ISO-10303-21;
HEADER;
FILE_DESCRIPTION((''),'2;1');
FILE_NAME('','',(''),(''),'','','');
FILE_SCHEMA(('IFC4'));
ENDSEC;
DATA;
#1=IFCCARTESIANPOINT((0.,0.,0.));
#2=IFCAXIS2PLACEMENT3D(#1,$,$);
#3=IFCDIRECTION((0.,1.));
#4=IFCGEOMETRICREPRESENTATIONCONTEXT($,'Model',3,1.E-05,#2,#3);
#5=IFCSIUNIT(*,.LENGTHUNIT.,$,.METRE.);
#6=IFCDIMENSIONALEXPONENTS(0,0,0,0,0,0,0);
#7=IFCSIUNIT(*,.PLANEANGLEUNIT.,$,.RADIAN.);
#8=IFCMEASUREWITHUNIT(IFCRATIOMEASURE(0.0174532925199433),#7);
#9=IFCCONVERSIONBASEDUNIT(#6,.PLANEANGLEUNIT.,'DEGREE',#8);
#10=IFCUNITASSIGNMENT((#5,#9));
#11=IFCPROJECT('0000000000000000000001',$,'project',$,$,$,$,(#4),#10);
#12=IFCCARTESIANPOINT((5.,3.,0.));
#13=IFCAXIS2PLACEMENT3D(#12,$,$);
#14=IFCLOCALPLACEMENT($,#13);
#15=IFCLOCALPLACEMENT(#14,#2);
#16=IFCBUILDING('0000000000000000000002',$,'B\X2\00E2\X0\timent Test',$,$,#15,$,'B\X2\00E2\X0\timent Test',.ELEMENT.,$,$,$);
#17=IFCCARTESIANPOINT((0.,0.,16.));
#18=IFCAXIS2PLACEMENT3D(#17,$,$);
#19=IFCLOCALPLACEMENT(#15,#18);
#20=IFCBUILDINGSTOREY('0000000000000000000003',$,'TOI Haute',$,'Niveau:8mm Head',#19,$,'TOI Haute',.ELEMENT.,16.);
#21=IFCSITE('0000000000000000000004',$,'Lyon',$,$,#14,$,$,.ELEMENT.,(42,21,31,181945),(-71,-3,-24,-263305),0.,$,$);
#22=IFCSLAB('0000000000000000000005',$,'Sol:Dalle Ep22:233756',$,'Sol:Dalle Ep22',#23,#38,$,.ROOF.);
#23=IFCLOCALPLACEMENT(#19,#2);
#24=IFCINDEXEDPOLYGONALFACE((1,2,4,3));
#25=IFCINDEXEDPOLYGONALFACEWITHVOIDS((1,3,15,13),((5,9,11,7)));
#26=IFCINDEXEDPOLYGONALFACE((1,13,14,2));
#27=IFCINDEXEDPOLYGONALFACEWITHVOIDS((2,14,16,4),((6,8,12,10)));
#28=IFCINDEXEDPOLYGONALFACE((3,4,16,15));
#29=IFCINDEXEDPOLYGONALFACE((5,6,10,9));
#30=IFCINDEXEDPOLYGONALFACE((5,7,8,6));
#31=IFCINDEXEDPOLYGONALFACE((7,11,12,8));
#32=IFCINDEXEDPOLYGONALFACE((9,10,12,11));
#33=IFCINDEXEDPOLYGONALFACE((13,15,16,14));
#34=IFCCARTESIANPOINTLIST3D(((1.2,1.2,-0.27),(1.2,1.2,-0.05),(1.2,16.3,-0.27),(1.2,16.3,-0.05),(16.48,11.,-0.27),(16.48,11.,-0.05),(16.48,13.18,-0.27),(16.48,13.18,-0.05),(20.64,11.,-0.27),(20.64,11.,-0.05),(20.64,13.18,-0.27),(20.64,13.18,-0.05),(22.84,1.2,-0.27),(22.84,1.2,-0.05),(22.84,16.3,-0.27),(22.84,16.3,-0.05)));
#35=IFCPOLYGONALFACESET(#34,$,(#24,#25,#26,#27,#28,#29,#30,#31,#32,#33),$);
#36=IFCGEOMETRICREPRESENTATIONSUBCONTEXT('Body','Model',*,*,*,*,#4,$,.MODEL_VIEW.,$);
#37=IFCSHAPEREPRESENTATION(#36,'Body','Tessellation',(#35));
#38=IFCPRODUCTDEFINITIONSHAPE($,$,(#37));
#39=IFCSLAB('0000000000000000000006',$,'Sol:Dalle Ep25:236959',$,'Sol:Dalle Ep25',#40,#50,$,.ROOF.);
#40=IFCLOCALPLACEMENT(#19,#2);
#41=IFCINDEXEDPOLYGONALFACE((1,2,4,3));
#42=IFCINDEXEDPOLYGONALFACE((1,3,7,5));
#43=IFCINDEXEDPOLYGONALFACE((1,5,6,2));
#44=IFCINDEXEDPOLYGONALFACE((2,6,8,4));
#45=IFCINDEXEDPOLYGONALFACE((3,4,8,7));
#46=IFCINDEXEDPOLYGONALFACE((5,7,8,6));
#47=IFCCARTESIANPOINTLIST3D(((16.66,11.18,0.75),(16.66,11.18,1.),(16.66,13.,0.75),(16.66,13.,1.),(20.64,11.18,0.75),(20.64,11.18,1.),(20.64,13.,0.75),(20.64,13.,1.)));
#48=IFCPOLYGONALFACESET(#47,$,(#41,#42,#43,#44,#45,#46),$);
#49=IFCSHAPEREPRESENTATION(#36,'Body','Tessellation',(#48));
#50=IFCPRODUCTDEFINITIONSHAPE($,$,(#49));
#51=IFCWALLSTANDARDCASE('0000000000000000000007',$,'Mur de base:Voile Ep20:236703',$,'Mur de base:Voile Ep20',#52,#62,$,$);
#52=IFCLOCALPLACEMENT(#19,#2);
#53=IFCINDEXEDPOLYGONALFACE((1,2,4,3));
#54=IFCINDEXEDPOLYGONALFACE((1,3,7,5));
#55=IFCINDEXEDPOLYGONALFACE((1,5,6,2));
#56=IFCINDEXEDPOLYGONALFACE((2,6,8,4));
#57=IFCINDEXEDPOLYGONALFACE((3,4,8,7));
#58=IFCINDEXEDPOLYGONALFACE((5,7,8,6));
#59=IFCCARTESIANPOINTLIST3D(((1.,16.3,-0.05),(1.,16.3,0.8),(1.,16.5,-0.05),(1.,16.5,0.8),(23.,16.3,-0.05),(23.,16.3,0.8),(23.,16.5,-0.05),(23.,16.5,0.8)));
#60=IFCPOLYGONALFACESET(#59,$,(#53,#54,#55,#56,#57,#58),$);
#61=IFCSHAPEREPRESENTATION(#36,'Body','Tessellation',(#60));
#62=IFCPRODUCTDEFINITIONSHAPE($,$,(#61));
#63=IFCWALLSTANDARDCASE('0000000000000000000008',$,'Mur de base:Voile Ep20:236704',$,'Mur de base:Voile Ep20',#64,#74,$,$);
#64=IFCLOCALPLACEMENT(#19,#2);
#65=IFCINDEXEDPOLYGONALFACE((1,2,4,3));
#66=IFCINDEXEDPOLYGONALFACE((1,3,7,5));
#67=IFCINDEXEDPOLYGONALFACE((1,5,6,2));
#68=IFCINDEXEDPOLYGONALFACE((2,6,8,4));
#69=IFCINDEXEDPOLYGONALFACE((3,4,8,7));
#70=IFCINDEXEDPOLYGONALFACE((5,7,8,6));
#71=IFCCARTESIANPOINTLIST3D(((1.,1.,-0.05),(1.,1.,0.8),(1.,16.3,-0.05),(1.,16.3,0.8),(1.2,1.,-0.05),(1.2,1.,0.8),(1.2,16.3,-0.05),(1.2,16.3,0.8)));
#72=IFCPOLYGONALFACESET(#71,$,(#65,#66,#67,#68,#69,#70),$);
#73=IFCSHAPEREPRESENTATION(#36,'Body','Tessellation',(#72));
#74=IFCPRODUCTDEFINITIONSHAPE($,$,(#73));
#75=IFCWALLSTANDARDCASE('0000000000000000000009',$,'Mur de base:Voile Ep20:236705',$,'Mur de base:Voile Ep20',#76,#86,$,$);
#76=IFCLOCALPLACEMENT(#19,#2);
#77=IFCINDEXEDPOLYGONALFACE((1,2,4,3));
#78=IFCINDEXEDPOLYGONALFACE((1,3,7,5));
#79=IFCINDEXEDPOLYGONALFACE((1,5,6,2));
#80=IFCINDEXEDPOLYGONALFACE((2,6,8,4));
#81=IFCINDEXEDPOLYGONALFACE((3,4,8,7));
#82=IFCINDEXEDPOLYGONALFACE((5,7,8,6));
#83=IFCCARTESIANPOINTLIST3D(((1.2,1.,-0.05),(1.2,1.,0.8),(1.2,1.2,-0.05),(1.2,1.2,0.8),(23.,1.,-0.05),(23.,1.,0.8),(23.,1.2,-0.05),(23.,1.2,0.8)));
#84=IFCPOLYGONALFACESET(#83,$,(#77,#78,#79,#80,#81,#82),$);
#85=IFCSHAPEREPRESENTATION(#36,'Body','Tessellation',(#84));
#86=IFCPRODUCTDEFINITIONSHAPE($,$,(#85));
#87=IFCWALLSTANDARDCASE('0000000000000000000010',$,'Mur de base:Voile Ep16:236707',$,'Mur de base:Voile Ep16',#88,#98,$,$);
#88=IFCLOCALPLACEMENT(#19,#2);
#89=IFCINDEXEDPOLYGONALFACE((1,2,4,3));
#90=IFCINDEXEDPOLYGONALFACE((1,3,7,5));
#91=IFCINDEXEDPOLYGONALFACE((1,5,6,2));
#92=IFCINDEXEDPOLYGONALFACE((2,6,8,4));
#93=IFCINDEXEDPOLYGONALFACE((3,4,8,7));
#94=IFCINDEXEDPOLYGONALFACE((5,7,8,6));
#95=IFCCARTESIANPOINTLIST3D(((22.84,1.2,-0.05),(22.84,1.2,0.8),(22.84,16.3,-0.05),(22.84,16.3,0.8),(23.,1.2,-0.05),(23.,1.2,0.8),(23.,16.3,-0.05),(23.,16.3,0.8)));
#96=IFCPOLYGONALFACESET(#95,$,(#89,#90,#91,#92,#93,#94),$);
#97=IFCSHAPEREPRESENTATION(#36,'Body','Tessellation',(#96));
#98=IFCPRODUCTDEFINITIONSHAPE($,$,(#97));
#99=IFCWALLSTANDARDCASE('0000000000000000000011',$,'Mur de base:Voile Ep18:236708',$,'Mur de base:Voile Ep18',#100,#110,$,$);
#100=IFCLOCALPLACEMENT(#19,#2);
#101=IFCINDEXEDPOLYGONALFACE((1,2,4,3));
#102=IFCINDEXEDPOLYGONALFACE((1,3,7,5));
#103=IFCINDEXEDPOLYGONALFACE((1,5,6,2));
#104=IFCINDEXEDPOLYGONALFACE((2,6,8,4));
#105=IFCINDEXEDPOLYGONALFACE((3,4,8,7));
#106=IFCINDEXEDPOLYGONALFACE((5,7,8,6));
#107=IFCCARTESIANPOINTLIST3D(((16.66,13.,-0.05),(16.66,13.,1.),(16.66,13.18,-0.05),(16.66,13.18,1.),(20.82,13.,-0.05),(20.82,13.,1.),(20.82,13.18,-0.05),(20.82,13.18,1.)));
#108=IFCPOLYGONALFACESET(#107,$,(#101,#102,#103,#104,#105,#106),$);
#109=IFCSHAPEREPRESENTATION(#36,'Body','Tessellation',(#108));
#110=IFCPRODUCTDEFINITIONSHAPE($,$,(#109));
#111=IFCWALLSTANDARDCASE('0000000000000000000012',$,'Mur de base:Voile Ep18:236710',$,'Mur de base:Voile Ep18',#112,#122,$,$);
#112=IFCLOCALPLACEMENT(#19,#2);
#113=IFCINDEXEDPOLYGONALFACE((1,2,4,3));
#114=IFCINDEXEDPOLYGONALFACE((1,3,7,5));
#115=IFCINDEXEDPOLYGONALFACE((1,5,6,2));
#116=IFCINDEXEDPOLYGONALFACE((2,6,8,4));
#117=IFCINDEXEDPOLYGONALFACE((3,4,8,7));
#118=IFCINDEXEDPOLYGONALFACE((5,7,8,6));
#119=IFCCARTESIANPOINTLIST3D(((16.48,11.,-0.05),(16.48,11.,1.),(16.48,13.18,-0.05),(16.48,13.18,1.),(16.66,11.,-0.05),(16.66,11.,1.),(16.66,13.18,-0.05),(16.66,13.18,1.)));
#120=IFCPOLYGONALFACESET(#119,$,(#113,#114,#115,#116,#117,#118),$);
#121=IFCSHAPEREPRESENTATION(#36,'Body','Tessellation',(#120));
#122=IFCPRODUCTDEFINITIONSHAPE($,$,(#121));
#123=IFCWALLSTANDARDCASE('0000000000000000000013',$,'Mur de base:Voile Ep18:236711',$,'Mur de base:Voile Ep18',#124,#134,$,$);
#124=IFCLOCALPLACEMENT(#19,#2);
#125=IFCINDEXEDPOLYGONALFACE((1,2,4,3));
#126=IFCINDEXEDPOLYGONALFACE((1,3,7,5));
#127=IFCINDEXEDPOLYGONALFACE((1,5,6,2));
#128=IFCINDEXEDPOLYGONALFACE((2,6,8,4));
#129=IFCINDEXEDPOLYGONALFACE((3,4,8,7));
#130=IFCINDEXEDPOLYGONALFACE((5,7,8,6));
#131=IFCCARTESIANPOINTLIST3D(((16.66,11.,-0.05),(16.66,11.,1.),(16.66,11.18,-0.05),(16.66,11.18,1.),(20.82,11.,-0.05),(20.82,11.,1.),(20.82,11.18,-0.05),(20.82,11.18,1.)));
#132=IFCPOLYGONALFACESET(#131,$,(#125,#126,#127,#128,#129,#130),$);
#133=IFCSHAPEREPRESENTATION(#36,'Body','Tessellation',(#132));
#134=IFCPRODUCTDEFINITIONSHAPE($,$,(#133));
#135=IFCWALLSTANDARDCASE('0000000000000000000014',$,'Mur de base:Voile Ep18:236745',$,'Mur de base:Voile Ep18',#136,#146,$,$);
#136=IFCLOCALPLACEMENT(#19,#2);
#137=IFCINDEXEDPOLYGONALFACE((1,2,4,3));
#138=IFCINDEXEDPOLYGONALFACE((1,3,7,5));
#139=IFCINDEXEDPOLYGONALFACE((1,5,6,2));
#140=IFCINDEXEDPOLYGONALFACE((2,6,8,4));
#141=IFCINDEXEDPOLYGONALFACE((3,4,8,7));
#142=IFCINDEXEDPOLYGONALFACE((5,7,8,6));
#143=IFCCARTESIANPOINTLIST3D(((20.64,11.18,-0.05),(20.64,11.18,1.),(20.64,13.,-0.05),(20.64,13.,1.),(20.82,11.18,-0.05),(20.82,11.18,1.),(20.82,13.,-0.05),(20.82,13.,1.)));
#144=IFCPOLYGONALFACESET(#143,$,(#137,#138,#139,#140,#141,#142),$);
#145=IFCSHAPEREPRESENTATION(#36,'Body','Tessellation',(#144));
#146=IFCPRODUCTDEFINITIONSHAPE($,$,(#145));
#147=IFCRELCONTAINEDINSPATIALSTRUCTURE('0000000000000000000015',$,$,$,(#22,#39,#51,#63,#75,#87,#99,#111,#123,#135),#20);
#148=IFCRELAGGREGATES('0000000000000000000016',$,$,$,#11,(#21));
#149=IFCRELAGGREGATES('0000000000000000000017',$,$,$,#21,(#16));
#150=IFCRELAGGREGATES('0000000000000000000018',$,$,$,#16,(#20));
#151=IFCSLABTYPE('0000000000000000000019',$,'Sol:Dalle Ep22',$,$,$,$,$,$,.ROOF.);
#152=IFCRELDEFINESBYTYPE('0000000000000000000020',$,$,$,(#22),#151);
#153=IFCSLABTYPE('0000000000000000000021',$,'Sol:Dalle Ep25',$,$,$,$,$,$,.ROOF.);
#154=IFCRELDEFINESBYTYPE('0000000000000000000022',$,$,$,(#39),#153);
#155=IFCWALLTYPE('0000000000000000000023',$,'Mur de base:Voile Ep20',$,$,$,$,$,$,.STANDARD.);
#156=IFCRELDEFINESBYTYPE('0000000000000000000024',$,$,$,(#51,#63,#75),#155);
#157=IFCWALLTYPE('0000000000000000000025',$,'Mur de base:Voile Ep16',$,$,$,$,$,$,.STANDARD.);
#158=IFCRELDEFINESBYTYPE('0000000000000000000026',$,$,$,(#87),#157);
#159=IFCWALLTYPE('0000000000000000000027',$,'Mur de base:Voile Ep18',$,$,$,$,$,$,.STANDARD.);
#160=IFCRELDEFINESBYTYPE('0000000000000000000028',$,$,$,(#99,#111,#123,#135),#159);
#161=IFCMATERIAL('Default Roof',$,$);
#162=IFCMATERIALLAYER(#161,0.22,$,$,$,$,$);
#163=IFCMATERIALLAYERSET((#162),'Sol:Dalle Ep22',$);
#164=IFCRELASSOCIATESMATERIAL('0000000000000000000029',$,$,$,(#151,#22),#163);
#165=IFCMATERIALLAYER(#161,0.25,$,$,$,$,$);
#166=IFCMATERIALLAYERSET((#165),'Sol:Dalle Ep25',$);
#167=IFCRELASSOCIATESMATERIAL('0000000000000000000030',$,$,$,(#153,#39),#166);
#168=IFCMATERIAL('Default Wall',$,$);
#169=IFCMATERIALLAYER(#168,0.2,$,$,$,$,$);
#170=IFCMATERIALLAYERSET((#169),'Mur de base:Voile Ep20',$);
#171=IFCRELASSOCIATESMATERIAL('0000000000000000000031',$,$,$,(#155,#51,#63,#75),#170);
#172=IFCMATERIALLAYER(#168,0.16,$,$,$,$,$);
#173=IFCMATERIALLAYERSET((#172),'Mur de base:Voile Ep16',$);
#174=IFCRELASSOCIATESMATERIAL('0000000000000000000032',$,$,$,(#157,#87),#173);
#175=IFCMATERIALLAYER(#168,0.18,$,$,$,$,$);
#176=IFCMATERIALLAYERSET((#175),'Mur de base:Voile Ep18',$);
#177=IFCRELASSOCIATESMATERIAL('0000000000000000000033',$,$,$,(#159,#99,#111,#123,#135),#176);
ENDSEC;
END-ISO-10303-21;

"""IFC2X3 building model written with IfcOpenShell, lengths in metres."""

from ifc_helpers import new_model, entity, si_unit, converted_unit, direction, frame, frame_2d, origin, origin_2d_with_axis, place, context, subcontext, project, spatial, rectangle, extrude, material, layer, layer_set, layer_usage, type_object, element, save


model = new_model("IFC2X3")

# Units and contexts
model_context = context("Model", 3, precision=1e-05, world=origin(), true_north=direction((0.0, 1.0)))
body_context = subcontext(model_context, "Body", "Model", "MODEL_VIEW")
ifc_project = project(units=[si_unit("LENGTHUNIT", "METRE"), converted_unit("PLANEANGLEUNIT", "DEGREE", entity("IfcRatioMeasure", 0.0174532925199433), si_unit("PLANEANGLEUNIT", "RADIAN"), dimensions=[0, 0, 0, 0, 0, 0, 0])], contexts=[model_context])

# Site, building, storey
site_placement = place(None, frame((5.0, 3.0, 0.0)))
site = spatial("IfcSite", under=ifc_project, at=site_placement, Name="Lyon", CompositionType="ELEMENT", RefLatitude=(42, 21, 31, 181945), RefLongitude=(-71, -3, -24, -263305), RefElevation=0.0)
building_placement = place(site_placement, origin())
building = spatial("IfcBuilding", under=site, at=building_placement, Name="Bâtiment Test", LongName="Bâtiment Test", CompositionType="ELEMENT")
storey_placement = place(building_placement, frame((0.0, 0.0, 16.0)))
storey = spatial("IfcBuildingStorey", under=building, at=storey_placement, Name="TOI Haute", ObjectType="Niveau:8mm Head", LongName="TOI Haute", CompositionType="ELEMENT", Elevation=16.0)

# Slab, opening
ifc_material_1 = material(Name="Default Roof")
ifc_layer_1 = layer(ifc_material_1, 0.22)
ifc_layer_set_1 = layer_set([ifc_layer_1], Name="Sol:Dalle Ep22")
ifc_layer_usage_1 = layer_usage(ifc_layer_set_1, "AXIS3", "POSITIVE", 0.0)
slab_type_1 = type_object("IfcSlabType", Name="Sol:Dalle Ep22", PredefinedType="ROOF", material=ifc_layer_set_1)
slab_1_placement = place(storey_placement, frame((1.2, 1.2, -0.27)))
slab_1 = element("IfcSlab", 1, at=slab_1_placement, inside=storey, type_object=slab_type_1, material=ifc_layer_usage_1, Name="Sol:Dalle Ep22:233756", ObjectType="Sol:Dalle Ep22", PredefinedType="ROOF", context=body_context, shape_type="SweptSolid", body=[
    extrude(rectangle(XDim=21.64, YDim=15.1, at=frame_2d((0.0, 0.0), x_axis=(-1.0, 0.0))), frame((10.82, 7.55, 0.22), z_axis=(0.0, 0.0, -1.0), x_axis=(-1.0, 0.0, 0.0)), (0.0, 0.0, 1.0), 0.22),
])
opening_placement = place(slab_1_placement, frame((17.36, 10.89, 0.22)))
element("IfcOpeningElement", 2, at=opening_placement, cuts=slab_1, ObjectType="Opening", context=body_context, shape_type="SweptSolid", body=[
    extrude(rectangle(XDim=4.16, YDim=2.18, at=origin_2d_with_axis()), frame((0.0, 0.0, 0.0), z_axis=(0.0, 0.0, -1.0), x_axis=(-1.0, 0.0, 0.0)), (0.0, 0.0, 1.0), 0.22),
])

# Slab
ifc_layer_2 = layer(ifc_material_1, 0.25)
ifc_layer_set_2 = layer_set([ifc_layer_2], Name="Sol:Dalle Ep25")
ifc_layer_usage_2 = layer_usage(ifc_layer_set_2, "AXIS3", "POSITIVE", 0.0)
slab_type_2 = type_object("IfcSlabType", Name="Sol:Dalle Ep25", PredefinedType="ROOF", material=ifc_layer_set_2)
slab_2_placement = place(storey_placement, origin())
element("IfcSlab", 3, at=slab_2_placement, inside=storey, type_object=slab_type_2, material=ifc_layer_usage_2, Name="Sol:Dalle Ep25:236959", ObjectType="Sol:Dalle Ep25", PredefinedType="ROOF", context=body_context, shape_type="SweptSolid", body=[
    extrude(rectangle(XDim=1.82, YDim=3.98, at=frame_2d((0.0, 0.0), x_axis=(1.0, 0.0))), frame((18.65, 12.09, 1.0), z_axis=(0.0, 0.0, -1.0), x_axis=(0.0, 1.0, 0.0)), (0.0, 0.0, 1.0), 0.25),
])

# Walls
ifc_material_2 = material(Name="Default Wall")
ifc_layer_3 = layer(ifc_material_2, 0.2)
ifc_layer_set_3 = layer_set([ifc_layer_3], Name="Mur de base:Voile Ep20")
ifc_layer_usage_3 = layer_usage(ifc_layer_set_3, "AXIS2", "POSITIVE", -0.1)
wall_type_1 = type_object("IfcWallType", Name="Mur de base:Voile Ep20", PredefinedType="STANDARD", material=ifc_layer_set_3)
wall_1_placement = place(storey_placement, frame((23.0, 16.4, -0.05), z_axis=(0.0, 0.0, 1.0), x_axis=(-1.0, 0.0, 0.0)))
element("IfcWallStandardCase", 4, at=wall_1_placement, inside=storey, type_object=wall_type_1, material=ifc_layer_usage_3, Name="Mur de base:Voile Ep20:236703", ObjectType="Mur de base:Voile Ep20", context=body_context, shape_type="SweptSolid", body=[
    extrude(rectangle(XDim=22.0, YDim=0.2, at=frame_2d((11.0, 0.0), x_axis=(-1.0, 0.0))), origin(), (0.0, 0.0, 1.0), 0.85),
])
ifc_layer_usage_4 = layer_usage(ifc_layer_set_3, "AXIS2", "POSITIVE", -0.1)
wall_2_placement = place(storey_placement, frame((1.1, 16.3, -0.05), z_axis=(0.0, 0.0, 1.0), x_axis=(0.0, -1.0, 0.0)))
element("IfcWallStandardCase", 5, at=wall_2_placement, inside=storey, type_object=wall_type_1, material=ifc_layer_usage_4, Name="Mur de base:Voile Ep20:236704", ObjectType="Mur de base:Voile Ep20", context=body_context, shape_type="SweptSolid", body=[
    extrude(rectangle(XDim=15.3, YDim=0.2, at=frame_2d((7.65, 0.0), x_axis=(-1.0, 0.0))), origin(), (0.0, 0.0, 1.0), 0.85),
])
ifc_layer_usage_5 = layer_usage(ifc_layer_set_3, "AXIS2", "POSITIVE", -0.1)
wall_3_placement = place(storey_placement, frame((1.2, 1.1, -0.05)))
element("IfcWallStandardCase", 6, at=wall_3_placement, inside=storey, type_object=wall_type_1, material=ifc_layer_usage_5, Name="Mur de base:Voile Ep20:236705", ObjectType="Mur de base:Voile Ep20", context=body_context, shape_type="SweptSolid", body=[
    extrude(rectangle(XDim=21.8, YDim=0.2, at=frame_2d((10.9, 0.0), x_axis=(-1.0, 0.0))), origin(), (0.0, 0.0, 1.0), 0.85),
])
ifc_layer_4 = layer(ifc_material_2, 0.16)
ifc_layer_set_4 = layer_set([ifc_layer_4], Name="Mur de base:Voile Ep16")
ifc_layer_usage_6 = layer_usage(ifc_layer_set_4, "AXIS2", "NEGATIVE", 0.08)
wall_type_2 = type_object("IfcWallType", Name="Mur de base:Voile Ep16", PredefinedType="STANDARD", material=ifc_layer_set_4)
wall_4_placement = place(storey_placement, frame((22.92, 16.3, -0.05), z_axis=(0.0, 0.0, 1.0), x_axis=(0.0, -1.0, 0.0)))
element("IfcWallStandardCase", 7, at=wall_4_placement, inside=storey, type_object=wall_type_2, material=ifc_layer_usage_6, Name="Mur de base:Voile Ep16:236707", ObjectType="Mur de base:Voile Ep16", context=body_context, shape_type="SweptSolid", body=[
    extrude(rectangle(XDim=15.1, YDim=0.16, at=frame_2d((7.55, 0.0), x_axis=(-1.0, 0.0))), origin(), (0.0, 0.0, 1.0), 0.85),
])
ifc_layer_5 = layer(ifc_material_2, 0.18)
ifc_layer_set_5 = layer_set([ifc_layer_5], Name="Mur de base:Voile Ep18")
ifc_layer_usage_7 = layer_usage(ifc_layer_set_5, "AXIS2", "NEGATIVE", 0.09)
wall_type_3 = type_object("IfcWallType", Name="Mur de base:Voile Ep18", PredefinedType="STANDARD", material=ifc_layer_set_5)
wall_5_placement = place(storey_placement, frame((20.82, 13.09, -0.05), z_axis=(0.0, 0.0, 1.0), x_axis=(-1.0, 0.0, 0.0)))
element("IfcWallStandardCase", 8, at=wall_5_placement, inside=storey, type_object=wall_type_3, material=ifc_layer_usage_7, Name="Mur de base:Voile Ep18:236708", ObjectType="Mur de base:Voile Ep18", context=body_context, shape_type="SweptSolid", body=[
    extrude(rectangle(XDim=4.16, YDim=0.18, at=frame_2d((2.08, 0.0), x_axis=(-1.0, 0.0))), origin(), (0.0, 0.0, 1.0), 1.05),
])
ifc_layer_usage_8 = layer_usage(ifc_layer_set_5, "AXIS2", "NEGATIVE", 0.09)
wall_6_placement = place(storey_placement, frame((16.57, 13.18, -0.05), z_axis=(0.0, 0.0, 1.0), x_axis=(0.0, -1.0, 0.0)))
element("IfcWallStandardCase", 9, at=wall_6_placement, inside=storey, type_object=wall_type_3, material=ifc_layer_usage_8, Name="Mur de base:Voile Ep18:236710", ObjectType="Mur de base:Voile Ep18", context=body_context, shape_type="SweptSolid", body=[
    extrude(rectangle(XDim=2.18, YDim=0.18, at=frame_2d((1.09, 0.0), x_axis=(-1.0, 0.0))), origin(), (0.0, 0.0, 1.0), 1.05),
])
ifc_layer_usage_9 = layer_usage(ifc_layer_set_5, "AXIS2", "POSITIVE", -0.09)
wall_7_placement = place(storey_placement, frame((16.66, 11.09, -0.05)))
element("IfcWallStandardCase", 10, at=wall_7_placement, inside=storey, type_object=wall_type_3, material=ifc_layer_usage_9, Name="Mur de base:Voile Ep18:236711", ObjectType="Mur de base:Voile Ep18", context=body_context, shape_type="SweptSolid", body=[
    extrude(rectangle(XDim=4.16, YDim=0.18, at=frame_2d((2.08, 0.0), x_axis=(-1.0, 0.0))), origin(), (0.0, 0.0, 1.0), 1.05),
])
ifc_layer_usage_10 = layer_usage(ifc_layer_set_5, "AXIS2", "NEGATIVE", 0.09)
wall_8_placement = place(storey_placement, frame((20.73, 13.0, -0.05), z_axis=(0.0, 0.0, 1.0), x_axis=(0.0, -1.0, 0.0)))
element("IfcWallStandardCase", 11, at=wall_8_placement, inside=storey, type_object=wall_type_3, material=ifc_layer_usage_10, Name="Mur de base:Voile Ep18:236745", ObjectType="Mur de base:Voile Ep18", context=body_context, shape_type="SweptSolid", body=[
    extrude(rectangle(XDim=1.82, YDim=0.18, at=frame_2d((0.91, 0.0), x_axis=(-1.0, 0.0))), origin(), (0.0, 0.0, 1.0), 1.05),
])

save(model, "model.ifc")
